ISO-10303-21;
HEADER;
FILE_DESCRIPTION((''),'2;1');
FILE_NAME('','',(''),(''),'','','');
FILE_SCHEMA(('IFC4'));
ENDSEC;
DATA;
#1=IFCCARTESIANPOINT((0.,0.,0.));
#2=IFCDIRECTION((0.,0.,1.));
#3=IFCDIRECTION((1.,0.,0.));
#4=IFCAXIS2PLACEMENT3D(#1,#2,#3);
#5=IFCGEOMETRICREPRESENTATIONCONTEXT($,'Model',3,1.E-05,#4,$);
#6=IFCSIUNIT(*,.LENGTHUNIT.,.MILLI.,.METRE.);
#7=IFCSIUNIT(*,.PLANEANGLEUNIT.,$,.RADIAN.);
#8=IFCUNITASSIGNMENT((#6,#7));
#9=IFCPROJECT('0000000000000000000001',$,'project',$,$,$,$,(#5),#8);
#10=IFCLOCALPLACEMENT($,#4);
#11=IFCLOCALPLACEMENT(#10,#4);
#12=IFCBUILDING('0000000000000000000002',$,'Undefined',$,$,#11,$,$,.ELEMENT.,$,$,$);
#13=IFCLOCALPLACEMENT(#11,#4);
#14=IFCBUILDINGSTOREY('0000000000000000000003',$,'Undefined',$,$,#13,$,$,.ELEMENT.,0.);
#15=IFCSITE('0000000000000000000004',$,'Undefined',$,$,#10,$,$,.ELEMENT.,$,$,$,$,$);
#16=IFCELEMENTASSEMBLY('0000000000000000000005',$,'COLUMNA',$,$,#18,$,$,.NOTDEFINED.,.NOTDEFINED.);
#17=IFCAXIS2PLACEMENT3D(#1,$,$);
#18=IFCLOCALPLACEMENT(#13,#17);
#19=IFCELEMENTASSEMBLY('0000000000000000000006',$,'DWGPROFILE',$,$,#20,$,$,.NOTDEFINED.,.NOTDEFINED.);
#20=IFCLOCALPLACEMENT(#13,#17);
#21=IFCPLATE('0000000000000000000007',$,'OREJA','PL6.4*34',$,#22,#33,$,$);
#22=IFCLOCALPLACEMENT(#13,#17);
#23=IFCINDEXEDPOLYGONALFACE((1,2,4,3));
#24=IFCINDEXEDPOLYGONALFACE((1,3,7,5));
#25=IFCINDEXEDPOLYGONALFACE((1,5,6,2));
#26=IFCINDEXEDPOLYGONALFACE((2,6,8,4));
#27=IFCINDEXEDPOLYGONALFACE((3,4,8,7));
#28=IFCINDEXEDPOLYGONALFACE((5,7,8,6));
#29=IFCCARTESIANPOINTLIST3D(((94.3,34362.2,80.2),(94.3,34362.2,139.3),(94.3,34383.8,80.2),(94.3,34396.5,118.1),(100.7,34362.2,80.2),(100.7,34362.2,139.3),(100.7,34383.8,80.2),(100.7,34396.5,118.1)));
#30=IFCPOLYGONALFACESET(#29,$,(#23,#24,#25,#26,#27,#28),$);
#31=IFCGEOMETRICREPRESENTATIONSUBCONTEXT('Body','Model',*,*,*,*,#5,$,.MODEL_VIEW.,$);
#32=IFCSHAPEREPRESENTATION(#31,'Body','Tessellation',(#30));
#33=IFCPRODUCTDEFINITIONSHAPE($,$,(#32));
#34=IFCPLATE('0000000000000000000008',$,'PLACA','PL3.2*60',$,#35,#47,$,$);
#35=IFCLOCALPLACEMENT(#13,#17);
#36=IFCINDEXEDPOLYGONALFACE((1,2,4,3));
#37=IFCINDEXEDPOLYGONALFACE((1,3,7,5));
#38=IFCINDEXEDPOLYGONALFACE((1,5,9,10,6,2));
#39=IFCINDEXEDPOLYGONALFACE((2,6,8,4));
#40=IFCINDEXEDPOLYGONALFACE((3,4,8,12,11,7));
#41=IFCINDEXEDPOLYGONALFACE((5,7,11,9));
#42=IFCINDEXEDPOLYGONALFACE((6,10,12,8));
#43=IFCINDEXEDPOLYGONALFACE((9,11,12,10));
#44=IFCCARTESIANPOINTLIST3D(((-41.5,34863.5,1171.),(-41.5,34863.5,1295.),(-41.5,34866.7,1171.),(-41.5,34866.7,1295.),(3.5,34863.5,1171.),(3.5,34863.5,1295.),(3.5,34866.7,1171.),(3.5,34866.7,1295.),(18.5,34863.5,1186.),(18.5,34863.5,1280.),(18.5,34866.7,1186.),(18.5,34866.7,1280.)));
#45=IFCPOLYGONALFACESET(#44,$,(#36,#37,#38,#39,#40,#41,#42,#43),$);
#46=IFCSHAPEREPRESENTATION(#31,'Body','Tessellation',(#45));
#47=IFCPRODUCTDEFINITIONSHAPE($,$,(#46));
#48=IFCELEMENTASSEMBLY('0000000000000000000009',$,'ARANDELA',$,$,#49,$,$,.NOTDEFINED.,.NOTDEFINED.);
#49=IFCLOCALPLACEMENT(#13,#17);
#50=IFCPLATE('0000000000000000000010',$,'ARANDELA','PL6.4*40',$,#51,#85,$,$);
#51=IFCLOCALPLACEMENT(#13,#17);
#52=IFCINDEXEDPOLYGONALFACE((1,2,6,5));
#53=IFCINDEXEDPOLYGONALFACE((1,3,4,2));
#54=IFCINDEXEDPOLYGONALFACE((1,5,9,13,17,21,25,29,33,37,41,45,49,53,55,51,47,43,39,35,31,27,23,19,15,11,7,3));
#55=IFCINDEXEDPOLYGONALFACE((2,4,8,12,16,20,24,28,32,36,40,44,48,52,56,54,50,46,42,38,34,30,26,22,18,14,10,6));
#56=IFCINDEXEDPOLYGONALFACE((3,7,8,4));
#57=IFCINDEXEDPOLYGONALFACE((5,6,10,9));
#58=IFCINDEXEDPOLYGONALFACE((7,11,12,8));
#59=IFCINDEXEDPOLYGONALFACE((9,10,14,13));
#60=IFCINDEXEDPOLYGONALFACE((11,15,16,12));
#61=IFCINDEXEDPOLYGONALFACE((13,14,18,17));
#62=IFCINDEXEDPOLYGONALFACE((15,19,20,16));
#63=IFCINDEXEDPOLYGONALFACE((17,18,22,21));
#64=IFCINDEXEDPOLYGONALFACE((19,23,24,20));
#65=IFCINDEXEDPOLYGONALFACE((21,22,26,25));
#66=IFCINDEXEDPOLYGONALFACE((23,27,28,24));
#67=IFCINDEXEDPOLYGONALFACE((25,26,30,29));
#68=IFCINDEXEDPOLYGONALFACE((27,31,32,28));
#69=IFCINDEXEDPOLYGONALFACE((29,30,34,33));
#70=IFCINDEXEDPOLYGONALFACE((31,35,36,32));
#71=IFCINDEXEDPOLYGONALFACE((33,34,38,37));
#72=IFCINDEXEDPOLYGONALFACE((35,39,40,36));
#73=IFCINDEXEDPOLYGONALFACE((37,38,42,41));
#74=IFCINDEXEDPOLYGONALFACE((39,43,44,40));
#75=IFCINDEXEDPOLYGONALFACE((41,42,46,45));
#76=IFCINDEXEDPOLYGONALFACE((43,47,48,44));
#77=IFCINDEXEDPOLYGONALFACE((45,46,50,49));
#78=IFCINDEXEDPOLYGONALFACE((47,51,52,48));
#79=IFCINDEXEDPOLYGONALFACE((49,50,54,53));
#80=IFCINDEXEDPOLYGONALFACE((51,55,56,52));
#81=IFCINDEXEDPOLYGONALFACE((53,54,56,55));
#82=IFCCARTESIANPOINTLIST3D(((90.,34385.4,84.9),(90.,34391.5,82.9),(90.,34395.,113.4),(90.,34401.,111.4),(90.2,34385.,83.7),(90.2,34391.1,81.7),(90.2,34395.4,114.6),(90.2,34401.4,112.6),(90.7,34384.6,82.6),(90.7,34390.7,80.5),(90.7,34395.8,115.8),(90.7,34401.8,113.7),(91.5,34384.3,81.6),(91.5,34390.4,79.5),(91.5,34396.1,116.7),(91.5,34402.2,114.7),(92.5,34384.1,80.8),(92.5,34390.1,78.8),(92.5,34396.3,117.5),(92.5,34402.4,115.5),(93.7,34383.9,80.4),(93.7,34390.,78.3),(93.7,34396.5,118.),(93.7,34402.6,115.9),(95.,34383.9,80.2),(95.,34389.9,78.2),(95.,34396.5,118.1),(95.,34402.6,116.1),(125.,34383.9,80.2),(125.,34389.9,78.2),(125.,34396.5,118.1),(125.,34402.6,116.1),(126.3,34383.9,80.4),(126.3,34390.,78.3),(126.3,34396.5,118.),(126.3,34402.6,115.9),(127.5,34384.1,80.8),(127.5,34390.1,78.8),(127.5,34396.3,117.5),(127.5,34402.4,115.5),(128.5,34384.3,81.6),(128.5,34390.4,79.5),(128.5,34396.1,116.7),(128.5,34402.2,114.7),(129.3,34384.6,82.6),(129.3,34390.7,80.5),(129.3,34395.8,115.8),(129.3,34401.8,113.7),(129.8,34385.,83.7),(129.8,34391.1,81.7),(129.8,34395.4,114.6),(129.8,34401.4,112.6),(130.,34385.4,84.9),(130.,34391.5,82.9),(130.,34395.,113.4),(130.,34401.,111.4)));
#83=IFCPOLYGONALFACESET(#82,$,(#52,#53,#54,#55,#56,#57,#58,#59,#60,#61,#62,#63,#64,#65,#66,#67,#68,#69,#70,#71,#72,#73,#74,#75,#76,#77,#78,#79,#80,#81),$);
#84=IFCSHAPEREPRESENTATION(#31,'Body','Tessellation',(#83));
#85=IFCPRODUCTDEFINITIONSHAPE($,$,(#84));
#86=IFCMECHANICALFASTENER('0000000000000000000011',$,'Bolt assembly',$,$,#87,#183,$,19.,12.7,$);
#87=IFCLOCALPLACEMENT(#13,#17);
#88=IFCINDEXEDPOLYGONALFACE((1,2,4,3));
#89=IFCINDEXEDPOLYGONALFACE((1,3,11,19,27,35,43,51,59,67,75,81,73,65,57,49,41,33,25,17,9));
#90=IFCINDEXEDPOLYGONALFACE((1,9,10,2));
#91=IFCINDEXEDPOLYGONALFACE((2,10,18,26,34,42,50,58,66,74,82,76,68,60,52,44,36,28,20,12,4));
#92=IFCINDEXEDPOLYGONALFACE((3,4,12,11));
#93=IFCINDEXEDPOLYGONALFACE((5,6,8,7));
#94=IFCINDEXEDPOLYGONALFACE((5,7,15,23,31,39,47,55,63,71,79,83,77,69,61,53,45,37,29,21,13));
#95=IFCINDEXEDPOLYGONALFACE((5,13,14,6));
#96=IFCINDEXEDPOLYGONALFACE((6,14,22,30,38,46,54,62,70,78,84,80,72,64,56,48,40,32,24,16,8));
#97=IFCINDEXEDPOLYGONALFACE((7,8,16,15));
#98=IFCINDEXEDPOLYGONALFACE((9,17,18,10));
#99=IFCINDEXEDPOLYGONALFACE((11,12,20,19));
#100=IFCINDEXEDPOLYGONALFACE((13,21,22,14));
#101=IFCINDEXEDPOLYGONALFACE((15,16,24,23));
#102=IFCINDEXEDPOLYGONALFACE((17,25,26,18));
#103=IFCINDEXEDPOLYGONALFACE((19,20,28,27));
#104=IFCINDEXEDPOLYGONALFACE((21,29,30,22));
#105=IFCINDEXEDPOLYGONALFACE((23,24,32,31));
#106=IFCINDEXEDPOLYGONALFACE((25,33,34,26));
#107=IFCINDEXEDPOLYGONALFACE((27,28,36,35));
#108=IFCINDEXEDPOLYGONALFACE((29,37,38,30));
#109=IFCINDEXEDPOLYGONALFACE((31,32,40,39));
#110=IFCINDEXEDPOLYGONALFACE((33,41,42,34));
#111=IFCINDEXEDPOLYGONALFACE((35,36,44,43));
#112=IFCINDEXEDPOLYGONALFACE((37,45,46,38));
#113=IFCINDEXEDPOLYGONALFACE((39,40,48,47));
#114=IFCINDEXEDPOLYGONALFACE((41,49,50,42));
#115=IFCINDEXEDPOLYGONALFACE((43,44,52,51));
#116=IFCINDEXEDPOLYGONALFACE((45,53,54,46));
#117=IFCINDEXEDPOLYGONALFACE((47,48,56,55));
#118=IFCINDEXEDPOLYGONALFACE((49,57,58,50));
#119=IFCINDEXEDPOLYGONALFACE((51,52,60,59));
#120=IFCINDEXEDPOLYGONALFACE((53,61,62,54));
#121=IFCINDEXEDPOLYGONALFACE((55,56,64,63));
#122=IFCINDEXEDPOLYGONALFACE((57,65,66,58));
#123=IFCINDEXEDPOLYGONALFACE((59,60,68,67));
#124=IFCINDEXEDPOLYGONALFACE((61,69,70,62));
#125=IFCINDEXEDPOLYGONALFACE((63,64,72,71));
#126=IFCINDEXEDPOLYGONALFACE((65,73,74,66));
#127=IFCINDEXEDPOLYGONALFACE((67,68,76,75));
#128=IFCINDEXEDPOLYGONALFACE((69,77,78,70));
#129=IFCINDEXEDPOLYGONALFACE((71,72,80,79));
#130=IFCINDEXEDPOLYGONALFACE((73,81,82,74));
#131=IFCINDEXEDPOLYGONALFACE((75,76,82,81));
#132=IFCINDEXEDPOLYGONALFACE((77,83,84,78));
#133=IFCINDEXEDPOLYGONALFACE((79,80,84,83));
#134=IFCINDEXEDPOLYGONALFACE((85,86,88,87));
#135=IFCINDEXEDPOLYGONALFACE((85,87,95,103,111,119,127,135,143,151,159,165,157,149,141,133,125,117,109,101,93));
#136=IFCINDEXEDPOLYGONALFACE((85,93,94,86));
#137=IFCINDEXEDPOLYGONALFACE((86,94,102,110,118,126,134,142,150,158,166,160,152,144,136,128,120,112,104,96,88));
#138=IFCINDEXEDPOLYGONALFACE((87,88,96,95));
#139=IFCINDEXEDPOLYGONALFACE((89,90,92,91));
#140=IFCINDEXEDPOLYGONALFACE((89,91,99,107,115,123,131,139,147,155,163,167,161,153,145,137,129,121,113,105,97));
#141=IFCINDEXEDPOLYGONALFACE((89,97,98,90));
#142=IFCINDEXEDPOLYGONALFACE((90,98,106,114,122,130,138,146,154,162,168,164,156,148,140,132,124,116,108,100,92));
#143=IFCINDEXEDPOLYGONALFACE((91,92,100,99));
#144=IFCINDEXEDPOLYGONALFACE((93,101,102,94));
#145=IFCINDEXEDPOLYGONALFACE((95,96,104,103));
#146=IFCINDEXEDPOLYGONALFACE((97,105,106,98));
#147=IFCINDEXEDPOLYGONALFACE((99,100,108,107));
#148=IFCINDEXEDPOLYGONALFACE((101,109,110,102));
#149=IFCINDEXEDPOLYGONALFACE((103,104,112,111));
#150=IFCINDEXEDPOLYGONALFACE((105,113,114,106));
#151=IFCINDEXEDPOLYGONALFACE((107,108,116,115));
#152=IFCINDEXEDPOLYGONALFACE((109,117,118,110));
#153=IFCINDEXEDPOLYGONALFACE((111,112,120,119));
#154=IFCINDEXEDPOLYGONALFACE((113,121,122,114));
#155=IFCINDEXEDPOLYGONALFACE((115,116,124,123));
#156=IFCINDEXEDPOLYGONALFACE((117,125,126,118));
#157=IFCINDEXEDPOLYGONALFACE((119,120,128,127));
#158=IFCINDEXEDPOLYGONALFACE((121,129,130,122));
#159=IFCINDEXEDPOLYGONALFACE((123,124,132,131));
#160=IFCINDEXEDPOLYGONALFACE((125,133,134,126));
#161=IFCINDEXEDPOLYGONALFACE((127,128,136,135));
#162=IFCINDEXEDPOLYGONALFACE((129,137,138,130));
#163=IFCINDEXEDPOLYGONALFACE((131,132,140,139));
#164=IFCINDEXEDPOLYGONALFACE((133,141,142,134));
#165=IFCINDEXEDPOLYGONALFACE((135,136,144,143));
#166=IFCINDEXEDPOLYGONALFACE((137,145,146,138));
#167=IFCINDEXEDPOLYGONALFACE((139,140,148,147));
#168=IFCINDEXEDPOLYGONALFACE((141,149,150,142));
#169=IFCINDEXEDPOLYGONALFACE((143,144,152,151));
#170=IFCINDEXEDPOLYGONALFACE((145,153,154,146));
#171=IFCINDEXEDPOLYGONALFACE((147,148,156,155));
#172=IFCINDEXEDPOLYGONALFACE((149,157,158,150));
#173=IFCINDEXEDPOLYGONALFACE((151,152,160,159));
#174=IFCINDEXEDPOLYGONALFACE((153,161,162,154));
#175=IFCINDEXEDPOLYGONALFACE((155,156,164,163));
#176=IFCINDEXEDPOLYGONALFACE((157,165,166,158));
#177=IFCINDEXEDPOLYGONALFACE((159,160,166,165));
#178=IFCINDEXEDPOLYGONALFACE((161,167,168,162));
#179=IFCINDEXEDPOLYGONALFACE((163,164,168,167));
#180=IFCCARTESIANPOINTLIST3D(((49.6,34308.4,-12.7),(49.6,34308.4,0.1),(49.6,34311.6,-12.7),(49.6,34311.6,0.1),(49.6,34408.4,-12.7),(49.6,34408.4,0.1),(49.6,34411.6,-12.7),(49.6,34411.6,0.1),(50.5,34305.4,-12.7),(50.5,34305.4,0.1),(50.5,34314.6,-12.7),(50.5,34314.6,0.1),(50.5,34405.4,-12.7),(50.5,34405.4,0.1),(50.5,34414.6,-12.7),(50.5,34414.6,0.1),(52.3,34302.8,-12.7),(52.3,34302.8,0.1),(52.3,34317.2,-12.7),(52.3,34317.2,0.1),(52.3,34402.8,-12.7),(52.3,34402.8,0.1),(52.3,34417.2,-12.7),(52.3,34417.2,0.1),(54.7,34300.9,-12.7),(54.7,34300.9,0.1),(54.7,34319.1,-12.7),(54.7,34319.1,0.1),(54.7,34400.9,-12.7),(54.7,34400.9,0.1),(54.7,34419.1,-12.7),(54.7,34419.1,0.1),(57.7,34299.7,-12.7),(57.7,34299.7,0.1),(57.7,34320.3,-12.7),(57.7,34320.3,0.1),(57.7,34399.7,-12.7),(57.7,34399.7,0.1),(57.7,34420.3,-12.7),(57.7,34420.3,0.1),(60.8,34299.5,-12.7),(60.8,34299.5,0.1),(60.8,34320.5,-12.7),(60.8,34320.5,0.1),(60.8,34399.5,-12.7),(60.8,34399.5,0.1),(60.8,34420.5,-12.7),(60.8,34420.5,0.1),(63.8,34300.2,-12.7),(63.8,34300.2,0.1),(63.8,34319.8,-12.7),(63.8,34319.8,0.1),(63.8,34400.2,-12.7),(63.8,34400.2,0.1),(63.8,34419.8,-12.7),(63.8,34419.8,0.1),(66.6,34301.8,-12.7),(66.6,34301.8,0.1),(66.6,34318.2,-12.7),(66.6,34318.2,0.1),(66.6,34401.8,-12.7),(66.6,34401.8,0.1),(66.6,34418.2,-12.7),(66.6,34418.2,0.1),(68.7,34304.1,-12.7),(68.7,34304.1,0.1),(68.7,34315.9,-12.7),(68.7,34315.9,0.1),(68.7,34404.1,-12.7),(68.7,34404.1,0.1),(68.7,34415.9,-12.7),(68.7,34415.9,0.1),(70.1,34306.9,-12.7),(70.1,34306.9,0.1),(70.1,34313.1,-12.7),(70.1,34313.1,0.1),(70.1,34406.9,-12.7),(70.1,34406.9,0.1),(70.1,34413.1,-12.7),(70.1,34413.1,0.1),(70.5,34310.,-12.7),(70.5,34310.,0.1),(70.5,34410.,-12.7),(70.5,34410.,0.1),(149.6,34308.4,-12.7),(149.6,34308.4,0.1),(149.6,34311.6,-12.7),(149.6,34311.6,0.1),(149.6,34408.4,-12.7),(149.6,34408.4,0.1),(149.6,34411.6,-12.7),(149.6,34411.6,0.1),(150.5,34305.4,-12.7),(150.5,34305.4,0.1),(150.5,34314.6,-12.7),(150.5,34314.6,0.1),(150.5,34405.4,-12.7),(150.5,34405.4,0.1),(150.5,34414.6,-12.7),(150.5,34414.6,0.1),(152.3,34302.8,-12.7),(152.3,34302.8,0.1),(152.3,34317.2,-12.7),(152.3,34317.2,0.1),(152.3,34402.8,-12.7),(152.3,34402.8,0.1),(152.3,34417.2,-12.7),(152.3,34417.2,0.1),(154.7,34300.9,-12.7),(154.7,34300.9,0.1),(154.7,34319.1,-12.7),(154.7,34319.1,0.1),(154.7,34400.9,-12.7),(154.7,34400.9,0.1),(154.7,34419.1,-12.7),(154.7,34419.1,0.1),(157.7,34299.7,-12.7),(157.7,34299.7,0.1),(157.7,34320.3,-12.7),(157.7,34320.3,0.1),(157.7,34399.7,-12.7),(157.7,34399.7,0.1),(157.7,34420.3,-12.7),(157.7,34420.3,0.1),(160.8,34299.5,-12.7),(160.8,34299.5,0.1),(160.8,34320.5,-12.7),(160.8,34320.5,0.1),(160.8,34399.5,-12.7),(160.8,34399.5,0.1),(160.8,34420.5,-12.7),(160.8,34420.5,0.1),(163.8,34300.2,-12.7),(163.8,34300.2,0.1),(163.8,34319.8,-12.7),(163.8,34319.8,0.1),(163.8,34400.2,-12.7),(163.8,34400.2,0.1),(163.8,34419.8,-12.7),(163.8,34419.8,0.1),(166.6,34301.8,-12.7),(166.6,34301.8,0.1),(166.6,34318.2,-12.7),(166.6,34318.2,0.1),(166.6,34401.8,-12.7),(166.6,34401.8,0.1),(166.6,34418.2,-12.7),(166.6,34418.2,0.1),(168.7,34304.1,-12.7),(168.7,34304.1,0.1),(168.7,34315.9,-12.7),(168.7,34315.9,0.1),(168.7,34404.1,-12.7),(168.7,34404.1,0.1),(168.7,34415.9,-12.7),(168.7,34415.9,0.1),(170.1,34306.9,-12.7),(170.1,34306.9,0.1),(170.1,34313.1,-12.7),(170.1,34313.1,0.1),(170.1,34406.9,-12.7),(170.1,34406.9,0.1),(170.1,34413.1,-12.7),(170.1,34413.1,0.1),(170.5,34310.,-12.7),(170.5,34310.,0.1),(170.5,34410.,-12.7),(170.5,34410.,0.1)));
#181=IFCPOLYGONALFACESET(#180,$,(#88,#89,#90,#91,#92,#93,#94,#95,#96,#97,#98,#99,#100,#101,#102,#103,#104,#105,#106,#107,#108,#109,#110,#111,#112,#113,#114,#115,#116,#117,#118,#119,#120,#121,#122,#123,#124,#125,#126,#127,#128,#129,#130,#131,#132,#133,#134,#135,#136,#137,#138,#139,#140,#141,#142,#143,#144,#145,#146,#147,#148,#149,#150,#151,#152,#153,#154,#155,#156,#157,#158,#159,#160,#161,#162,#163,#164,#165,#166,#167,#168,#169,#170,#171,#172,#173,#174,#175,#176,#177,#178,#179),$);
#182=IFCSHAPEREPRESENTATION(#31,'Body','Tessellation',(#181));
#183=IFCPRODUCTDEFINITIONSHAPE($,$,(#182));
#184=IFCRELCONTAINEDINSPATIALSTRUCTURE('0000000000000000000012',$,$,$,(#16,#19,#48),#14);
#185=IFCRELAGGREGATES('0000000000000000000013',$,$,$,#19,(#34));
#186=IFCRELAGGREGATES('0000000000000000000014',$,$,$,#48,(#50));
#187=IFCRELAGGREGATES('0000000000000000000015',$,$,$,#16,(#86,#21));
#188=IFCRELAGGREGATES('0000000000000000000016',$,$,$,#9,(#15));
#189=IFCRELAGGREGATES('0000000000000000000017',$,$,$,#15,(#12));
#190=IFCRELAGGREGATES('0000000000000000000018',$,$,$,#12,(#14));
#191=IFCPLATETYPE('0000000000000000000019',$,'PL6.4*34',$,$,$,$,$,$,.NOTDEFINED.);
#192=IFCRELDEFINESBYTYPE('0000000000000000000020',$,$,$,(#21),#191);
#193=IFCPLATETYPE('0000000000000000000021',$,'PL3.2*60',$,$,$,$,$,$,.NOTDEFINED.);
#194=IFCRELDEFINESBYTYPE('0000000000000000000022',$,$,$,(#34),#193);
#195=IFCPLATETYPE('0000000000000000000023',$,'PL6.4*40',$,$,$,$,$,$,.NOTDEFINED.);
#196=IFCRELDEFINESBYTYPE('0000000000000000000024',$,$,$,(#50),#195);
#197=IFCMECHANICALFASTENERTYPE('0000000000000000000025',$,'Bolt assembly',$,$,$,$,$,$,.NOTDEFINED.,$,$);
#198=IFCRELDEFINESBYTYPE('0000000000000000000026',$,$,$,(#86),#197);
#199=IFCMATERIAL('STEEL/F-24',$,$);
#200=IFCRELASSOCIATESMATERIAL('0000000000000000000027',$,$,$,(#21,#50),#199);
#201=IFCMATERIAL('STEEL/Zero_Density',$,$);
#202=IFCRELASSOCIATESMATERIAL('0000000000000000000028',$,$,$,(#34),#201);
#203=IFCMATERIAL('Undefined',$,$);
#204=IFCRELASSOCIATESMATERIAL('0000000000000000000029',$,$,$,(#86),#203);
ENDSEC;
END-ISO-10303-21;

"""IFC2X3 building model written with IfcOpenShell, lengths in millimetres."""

from ifc_helpers import new_model, si_unit, frame, frame_2d, origin_with_axes, origin_2d_with_axis, place, context, subcontext, project, spatial, polyline, circle_curve, parameter, trimmed, segment, composite_curve, circle, outline, extrude, source, transform, mapped, material, type_object, element, aggregate, save


model = new_model("IFC2X3")

# Units and contexts
model_context = context("Model", 3, precision=1e-05, world=origin_with_axes())
body_context = subcontext(model_context, "Body", "Model", "MODEL_VIEW")
ifc_project = project(units=[si_unit("LENGTHUNIT", "METRE", prefix="MILLI"), si_unit("PLANEANGLEUNIT", "RADIAN")], contexts=[model_context])

# Site, building, storey
site_placement = place(None, origin_with_axes())
site = spatial("IfcSite", under=ifc_project, at=site_placement, Name="Undefined", CompositionType="ELEMENT")
building_placement = place(site_placement, origin_with_axes())
building = spatial("IfcBuilding", under=site, at=building_placement, Name="Undefined", CompositionType="ELEMENT")
storey_placement = place(building_placement, origin_with_axes())
storey = spatial("IfcBuildingStorey", under=building, at=storey_placement, Name="Undefined", CompositionType="ELEMENT", Elevation=0.0)

# Element assembly
assembly_1_placement = place(storey_placement, origin_with_axes())
assembly_1 = element("IfcElementAssembly", 1, at=assembly_1_placement, inside=storey, Name="COLUMNA", AssemblyPlace="NOTDEFINED", PredefinedType="NOTDEFINED")
ifc_material_1 = material(Name="STEEL/F-24")

# Element assembly
assembly_2_placement = place(storey_placement, origin_with_axes())
assembly_2 = element("IfcElementAssembly", 2, at=assembly_2_placement, inside=storey, Name="DWGPROFILE", AssemblyPlace="NOTDEFINED", PredefinedType="NOTDEFINED")
ifc_material_2 = material(Name="STEEL/Zero_Density")

# Plates
plate_type_1 = type_object("IfcPlateType", Name="PL6.4*34", PredefinedType="NOTDEFINED")
plate_1_placement = place(assembly_1_placement, frame((97.5, 34362.2, 80.2), z_axis=(-1.0, 0.0, 0.0), x_axis=(0.0, 0.0, 1.0)))
plate_1 = element("IfcPlate", 3, at=plate_1_placement, type_object=plate_type_1, material=ifc_material_1, Name="OREJA", Description="PL6.4*34", context=body_context, shape_type="SweptSolid", body=[
    extrude(outline(polyline([(0.0, 0.0), (59.0, 0.0), (37.9, 34.3), (0.0, 21.6), (0.0, 0.0)])), frame((0.0, 0.0, -3.2), z_axis=(0.0, 0.0, 1.0), x_axis=(1.0, 0.0, 0.0)), (0.0, 0.0, 1.0), 6.4),
])
plate_type_2 = type_object("IfcPlateType", Name="PL3.2*60", PredefinedType="NOTDEFINED")
plate_2_placement = place(assembly_2_placement, frame((-41.5, 34865.1, 1171.0), z_axis=(0.0, -1.0, 0.0), x_axis=(1.0, 0.0, 0.0)))
plate_2 = element("IfcPlate", 4, at=plate_2_placement, type_object=plate_type_2, material=ifc_material_2, Name="PLACA", Description="PL3.2*60", context=body_context, shape_type="SweptSolid", body=[
    extrude(outline(polyline([(0.0, 0.0), (45.0, 0.0), (60.0, 15.0), (60.0, 109.0), (45.0, 124.0), (0.0, 124.0), (0.0, 0.0)])), frame((0.0, 0.0, -1.6), z_axis=(0.0, 0.0, 1.0), x_axis=(1.0, 0.0, 0.0)), (0.0, 0.0, 1.0), 3.2),
])
aggregate(assembly_2, [plate_2])

# Element assembly, plate
assembly_3_placement = place(storey_placement, origin_with_axes())
assembly_3 = element("IfcElementAssembly", 5, at=assembly_3_placement, inside=storey, Name="ARANDELA", AssemblyPlace="NOTDEFINED", PredefinedType="NOTDEFINED")
plate_type_3 = type_object("IfcPlateType", Name="PL6.4*40", PredefinedType="NOTDEFINED")
plate_3_placement = place(assembly_3_placement, frame((90.0, 34399.6, 117.1), z_axis=(0.0, -0.94833, 0.317285), x_axis=(0.0, -0.317285, -0.94833)))
plate_3 = element("IfcPlate", 6, at=plate_3_placement, type_object=plate_type_3, material=ifc_material_1, Name="ARANDELA", Description="PL6.4*40", context=body_context, shape_type="SweptSolid", body=[
    extrude(outline(composite_curve([segment(trimmed(circle_curve(frame_2d((5.0, 5.0), x_axis=(-1.0, 0.0)), 5.0), [parameter(0.0)], [parameter(1.570796)], True, "PARAMETER"), True, "CONTINUOUS"), segment(polyline([(5.0, 0.0), (35.0, 0.0)]), True, "CONTINUOUS"), segment(trimmed(circle_curve(frame_2d((35.0, 5.0), x_axis=(0.0, -1.0)), 5.0), [parameter(0.0)], [parameter(1.570796)], True, "PARAMETER"), True, "CONTINUOUS"), segment(polyline([(40.0, 5.0), (40.0, 35.0)]), True, "CONTINUOUS"), segment(trimmed(circle_curve(frame_2d((35.0, 35.0), x_axis=(1.0, 0.0)), 5.0), [parameter(0.0)], [parameter(1.570796)], True, "PARAMETER"), True, "CONTINUOUS"), segment(polyline([(35.0, 40.0), (5.0, 40.0)]), True, "CONTINUOUS"), segment(trimmed(circle_curve(frame_2d((5.0, 35.0), x_axis=(0.0, 1.0)), 5.0), [parameter(0.0)], [parameter(1.570796)], True, "PARAMETER"), True, "CONTINUOUS"), segment(polyline([(0.0, 35.0), (0.0, 5.0)]), True, "CONTINUOUS")], self_intersect=True)), frame((0.0, 0.0, -3.2), z_axis=(0.0, 0.0, 1.0), x_axis=(1.0, 0.0, 0.0)), (0.0, 0.0, 1.0), 6.4),
])

# Mechanical fastener
ifc_material_3 = material(Name="Undefined")
mechanical_fastener_type = type_object("IfcMechanicalFastenerType", Name="Bolt assembly")
shared_shape_1 = source(origin_with_axes(), body_context, "Body", "SweptSolid", [
    extrude(circle(Radius=10.5, at=origin_2d_with_axis()), frame((0.0, -22.7, 0.0), z_axis=(0.0, 1.0, 0.0), x_axis=(1.0, 0.0, 0.0)), (0.0, 0.0, 1.0), 12.8),
])
mechanical_fastener_1_placement = place(assembly_1_placement, frame((60.0, 34360.0, 10.0), z_axis=(0.0, -1.0, 0.0), x_axis=(1.0, 0.0, 0.0)))
mechanical_fastener_1 = element("IfcMechanicalFastener", 7, at=mechanical_fastener_1_placement, type_object=mechanical_fastener_type, material=ifc_material_3, Name="Bolt assembly", NominalDiameter=19.0, NominalLength=12.7, context=body_context, shape_type="MappedRepresentation", body=[
    mapped(shared_shape_1, transform((0.0, 0.0, -50.0))),
    mapped(shared_shape_1, transform((100.0, 0.0, -50.0))),
    mapped(shared_shape_1, transform((0.0, 0.0, 50.0))),
    mapped(shared_shape_1, transform((100.0, 0.0, 50.0))),
])
aggregate(assembly_3, [plate_3])
aggregate(assembly_1, [mechanical_fastener_1, plate_1])

save(model, "model.ifc")
